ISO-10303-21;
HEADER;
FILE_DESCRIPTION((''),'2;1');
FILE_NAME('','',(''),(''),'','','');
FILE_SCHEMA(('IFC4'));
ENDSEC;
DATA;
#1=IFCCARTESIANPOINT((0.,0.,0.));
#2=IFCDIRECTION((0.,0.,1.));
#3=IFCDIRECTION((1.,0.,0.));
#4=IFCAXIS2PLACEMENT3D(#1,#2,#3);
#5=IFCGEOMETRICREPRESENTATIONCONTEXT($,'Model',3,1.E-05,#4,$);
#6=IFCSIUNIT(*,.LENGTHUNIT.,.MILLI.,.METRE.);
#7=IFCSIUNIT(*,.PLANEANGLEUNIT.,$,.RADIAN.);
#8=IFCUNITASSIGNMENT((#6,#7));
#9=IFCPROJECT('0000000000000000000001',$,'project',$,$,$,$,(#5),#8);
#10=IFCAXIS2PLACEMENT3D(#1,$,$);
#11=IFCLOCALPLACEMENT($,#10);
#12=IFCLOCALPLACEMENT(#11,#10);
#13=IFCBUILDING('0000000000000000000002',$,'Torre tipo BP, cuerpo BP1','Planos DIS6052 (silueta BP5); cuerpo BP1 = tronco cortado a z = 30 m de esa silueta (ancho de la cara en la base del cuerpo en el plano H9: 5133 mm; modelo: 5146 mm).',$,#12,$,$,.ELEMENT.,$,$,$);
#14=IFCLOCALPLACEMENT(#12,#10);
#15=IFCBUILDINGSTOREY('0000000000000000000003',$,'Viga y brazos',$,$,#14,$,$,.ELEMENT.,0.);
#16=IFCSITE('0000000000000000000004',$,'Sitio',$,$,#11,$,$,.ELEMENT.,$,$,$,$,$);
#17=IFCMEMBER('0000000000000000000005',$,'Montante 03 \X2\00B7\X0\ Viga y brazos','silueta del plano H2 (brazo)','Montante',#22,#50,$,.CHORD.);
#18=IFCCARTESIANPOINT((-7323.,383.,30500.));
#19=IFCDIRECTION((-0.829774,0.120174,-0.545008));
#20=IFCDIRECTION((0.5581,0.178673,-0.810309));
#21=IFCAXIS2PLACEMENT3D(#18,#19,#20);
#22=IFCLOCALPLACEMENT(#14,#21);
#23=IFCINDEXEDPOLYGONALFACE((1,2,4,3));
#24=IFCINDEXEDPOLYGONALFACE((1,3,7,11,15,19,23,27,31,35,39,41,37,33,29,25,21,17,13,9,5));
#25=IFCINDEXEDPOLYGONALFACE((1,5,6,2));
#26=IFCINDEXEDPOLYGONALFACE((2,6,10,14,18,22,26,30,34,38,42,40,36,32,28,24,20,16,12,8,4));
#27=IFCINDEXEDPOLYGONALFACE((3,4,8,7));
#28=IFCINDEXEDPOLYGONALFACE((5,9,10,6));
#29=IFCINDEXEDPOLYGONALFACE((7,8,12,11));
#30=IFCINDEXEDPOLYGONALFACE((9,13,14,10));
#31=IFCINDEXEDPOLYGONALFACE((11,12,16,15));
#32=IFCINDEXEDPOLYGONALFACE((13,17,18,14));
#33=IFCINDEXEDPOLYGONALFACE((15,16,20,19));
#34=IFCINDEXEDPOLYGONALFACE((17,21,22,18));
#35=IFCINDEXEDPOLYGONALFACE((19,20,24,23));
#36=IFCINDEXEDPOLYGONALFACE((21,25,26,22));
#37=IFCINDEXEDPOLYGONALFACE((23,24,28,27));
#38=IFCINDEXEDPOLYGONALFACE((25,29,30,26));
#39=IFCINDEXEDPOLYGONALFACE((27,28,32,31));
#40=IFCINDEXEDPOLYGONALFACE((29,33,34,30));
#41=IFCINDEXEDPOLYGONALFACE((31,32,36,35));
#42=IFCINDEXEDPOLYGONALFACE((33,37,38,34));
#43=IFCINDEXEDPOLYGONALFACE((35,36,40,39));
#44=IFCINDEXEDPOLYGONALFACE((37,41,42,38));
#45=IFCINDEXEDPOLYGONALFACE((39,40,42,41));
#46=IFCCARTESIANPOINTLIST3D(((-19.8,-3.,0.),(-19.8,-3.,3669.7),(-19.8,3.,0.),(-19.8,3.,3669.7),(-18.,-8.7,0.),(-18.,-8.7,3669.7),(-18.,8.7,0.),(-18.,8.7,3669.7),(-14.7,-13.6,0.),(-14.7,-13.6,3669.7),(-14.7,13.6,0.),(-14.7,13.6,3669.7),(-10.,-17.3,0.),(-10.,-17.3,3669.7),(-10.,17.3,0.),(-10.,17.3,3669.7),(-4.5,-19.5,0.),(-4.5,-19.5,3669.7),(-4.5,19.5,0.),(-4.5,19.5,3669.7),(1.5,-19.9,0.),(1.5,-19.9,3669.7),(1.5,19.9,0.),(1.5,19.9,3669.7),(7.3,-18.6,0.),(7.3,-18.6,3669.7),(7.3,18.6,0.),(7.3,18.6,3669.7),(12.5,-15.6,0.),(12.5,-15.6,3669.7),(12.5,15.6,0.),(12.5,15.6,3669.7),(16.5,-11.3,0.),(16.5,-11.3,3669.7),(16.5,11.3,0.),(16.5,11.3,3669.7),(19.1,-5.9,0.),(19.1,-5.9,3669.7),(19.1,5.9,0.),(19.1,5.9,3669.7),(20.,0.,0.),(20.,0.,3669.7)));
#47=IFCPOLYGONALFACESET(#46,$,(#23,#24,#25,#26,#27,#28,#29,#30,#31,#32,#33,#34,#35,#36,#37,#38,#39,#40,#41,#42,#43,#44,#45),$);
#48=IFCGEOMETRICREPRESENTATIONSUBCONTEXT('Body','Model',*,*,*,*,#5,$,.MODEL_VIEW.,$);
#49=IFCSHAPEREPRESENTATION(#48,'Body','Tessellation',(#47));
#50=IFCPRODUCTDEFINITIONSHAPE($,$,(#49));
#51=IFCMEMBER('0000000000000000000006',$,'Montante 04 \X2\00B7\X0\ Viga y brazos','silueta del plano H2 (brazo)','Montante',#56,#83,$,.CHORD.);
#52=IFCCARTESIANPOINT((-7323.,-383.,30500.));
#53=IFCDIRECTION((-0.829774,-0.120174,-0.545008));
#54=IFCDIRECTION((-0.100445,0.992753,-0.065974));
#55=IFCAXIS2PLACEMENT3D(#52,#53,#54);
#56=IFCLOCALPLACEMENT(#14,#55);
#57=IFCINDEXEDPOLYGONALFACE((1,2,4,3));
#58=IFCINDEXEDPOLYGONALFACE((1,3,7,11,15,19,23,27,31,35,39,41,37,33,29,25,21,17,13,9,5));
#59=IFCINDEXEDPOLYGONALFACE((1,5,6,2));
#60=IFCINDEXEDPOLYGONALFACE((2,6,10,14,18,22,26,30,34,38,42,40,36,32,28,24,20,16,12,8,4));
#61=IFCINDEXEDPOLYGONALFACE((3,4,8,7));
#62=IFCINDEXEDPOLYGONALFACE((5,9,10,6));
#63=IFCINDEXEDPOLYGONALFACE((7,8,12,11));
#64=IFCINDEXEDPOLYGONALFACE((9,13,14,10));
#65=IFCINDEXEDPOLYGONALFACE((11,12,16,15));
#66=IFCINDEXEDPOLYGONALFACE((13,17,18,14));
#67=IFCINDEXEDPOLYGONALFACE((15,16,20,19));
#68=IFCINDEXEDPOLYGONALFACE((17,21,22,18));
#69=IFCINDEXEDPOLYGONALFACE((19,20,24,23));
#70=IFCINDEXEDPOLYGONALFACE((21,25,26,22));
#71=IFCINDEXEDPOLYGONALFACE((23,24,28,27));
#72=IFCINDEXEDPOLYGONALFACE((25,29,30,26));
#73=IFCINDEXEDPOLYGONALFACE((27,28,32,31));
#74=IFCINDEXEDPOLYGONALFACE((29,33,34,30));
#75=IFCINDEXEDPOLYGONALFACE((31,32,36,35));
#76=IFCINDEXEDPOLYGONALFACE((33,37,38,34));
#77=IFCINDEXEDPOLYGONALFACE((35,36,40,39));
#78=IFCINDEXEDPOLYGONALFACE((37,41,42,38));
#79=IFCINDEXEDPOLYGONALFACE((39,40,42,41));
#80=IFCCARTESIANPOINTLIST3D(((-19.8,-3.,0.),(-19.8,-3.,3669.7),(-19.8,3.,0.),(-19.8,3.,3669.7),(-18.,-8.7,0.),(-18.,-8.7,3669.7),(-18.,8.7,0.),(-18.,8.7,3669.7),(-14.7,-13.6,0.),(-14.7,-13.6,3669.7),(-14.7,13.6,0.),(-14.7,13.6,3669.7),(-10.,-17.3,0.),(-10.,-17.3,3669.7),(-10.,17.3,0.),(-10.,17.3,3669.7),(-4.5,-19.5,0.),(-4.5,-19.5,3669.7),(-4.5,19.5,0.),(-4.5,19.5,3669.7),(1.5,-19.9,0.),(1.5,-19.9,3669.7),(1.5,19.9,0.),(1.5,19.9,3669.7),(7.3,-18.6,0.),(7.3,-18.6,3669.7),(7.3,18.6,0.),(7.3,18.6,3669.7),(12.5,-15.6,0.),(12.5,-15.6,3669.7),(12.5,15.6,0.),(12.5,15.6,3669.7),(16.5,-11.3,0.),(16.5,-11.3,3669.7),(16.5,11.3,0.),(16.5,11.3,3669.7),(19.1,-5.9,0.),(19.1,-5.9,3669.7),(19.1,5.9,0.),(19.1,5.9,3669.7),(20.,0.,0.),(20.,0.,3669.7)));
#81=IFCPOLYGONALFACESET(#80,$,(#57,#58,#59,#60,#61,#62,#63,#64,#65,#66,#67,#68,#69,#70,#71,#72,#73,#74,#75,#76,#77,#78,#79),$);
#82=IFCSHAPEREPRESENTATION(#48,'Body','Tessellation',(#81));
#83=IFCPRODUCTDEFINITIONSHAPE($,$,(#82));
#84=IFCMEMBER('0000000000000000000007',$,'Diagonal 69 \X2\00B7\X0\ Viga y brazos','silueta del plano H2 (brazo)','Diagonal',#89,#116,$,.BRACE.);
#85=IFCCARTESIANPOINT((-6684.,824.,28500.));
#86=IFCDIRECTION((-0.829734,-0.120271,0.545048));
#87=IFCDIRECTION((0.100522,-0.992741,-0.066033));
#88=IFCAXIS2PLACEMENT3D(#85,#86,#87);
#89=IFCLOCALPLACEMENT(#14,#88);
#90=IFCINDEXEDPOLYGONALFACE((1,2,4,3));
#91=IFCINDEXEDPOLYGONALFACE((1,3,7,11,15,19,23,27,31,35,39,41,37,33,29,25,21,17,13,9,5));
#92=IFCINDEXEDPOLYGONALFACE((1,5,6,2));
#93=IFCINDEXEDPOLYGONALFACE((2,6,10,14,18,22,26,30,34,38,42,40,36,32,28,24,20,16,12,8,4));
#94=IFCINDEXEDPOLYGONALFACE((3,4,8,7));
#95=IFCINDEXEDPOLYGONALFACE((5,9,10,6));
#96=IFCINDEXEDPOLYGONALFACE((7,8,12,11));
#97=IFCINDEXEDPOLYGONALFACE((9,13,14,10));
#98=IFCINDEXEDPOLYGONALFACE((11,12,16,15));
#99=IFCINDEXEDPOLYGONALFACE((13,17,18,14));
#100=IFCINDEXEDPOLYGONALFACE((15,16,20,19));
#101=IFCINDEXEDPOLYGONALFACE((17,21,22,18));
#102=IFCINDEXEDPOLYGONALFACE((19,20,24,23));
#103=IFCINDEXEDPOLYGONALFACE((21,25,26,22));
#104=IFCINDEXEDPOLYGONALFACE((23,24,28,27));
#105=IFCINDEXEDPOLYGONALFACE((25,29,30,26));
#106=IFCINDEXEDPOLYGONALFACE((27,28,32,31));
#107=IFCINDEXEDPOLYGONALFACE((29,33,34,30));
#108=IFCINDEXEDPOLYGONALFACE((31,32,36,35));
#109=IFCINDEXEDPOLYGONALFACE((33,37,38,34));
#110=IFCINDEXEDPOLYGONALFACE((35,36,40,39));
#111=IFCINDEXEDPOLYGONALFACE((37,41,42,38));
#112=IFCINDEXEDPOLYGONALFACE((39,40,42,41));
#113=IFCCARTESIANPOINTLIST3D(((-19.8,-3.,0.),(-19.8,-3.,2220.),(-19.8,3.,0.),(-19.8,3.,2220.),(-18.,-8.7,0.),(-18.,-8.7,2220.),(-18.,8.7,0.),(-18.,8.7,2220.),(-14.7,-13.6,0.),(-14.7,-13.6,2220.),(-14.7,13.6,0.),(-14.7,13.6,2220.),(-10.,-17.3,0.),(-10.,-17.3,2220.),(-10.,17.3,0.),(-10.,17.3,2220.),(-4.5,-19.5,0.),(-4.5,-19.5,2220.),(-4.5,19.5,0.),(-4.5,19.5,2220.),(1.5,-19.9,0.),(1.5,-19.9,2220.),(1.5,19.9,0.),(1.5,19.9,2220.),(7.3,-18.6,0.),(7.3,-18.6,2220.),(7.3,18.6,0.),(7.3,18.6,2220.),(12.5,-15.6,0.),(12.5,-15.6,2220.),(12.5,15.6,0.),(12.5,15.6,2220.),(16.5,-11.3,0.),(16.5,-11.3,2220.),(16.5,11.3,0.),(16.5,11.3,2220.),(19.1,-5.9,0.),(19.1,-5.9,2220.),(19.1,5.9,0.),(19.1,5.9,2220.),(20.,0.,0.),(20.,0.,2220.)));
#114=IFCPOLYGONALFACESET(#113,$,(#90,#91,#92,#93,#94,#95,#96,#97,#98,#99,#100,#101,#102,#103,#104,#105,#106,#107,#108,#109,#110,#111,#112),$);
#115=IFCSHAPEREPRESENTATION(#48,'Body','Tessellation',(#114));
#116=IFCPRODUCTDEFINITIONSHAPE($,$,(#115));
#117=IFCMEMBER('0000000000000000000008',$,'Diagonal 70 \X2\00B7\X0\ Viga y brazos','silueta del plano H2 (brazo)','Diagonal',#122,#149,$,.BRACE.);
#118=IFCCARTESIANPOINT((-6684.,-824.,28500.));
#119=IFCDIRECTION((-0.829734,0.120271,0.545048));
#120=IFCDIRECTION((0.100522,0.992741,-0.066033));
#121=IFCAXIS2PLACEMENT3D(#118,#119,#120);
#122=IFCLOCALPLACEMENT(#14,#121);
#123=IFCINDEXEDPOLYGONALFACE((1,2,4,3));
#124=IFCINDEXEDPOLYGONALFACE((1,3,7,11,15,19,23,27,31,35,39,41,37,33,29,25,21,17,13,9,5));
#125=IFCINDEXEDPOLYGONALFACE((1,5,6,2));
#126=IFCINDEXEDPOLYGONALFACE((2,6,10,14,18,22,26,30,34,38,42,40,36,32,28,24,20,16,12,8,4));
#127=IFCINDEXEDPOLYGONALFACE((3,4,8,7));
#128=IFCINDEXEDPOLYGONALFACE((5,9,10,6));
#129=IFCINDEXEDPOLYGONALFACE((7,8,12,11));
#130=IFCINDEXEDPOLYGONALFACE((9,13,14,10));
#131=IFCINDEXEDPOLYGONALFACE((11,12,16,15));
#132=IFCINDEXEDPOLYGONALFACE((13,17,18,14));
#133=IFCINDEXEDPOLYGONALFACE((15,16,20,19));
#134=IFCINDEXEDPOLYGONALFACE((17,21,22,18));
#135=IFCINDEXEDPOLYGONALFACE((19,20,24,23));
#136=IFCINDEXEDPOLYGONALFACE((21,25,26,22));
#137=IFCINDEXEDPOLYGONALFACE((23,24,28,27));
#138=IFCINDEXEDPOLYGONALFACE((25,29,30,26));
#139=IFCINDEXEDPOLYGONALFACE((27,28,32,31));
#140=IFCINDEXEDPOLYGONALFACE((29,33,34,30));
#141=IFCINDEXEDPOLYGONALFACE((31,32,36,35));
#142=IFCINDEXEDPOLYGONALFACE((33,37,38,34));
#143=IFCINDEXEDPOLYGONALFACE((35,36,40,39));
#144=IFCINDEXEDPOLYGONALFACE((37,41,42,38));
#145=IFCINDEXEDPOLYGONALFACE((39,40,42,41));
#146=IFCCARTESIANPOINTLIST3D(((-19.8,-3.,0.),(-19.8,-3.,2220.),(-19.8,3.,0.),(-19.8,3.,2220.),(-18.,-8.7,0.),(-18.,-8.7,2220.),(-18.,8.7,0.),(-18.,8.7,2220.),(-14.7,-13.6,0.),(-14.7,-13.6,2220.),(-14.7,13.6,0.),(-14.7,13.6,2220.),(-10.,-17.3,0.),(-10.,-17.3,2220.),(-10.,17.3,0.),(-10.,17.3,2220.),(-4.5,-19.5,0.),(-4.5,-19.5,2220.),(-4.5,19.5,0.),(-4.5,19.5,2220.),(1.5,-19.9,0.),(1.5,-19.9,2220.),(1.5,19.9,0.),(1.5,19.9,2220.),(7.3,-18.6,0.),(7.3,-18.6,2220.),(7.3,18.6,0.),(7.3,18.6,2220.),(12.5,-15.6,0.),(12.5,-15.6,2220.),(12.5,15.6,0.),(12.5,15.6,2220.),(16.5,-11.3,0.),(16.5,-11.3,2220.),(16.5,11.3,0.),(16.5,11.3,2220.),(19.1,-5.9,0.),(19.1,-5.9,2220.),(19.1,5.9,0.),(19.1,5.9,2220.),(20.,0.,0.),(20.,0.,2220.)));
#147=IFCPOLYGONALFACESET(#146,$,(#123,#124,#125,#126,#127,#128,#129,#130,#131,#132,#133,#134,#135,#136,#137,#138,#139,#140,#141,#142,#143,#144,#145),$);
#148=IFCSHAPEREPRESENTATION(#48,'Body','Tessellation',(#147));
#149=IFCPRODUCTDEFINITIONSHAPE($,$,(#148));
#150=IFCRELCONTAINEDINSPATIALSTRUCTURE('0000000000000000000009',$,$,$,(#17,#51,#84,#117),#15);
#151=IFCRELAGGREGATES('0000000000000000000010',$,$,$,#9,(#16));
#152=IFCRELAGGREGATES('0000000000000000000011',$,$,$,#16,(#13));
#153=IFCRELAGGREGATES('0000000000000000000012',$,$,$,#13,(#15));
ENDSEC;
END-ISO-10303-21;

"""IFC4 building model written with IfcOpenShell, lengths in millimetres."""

from ifc_helpers import new_model, si_unit, frame, origin, origin_with_axes, place, context, subcontext, project, spatial, circle, extrude, element, save


model = new_model("IFC4")

# Units and contexts
model_context = context("Model", 3, precision=1e-05, world=origin_with_axes())
body_context = subcontext(model_context, "Body", "Model", "MODEL_VIEW")
ifc_project = project(units=[si_unit("LENGTHUNIT", "METRE", prefix="MILLI"), si_unit("PLANEANGLEUNIT", "RADIAN")], contexts=[model_context])

# Site, building, storey
site_placement = place(None, origin())
site = spatial("IfcSite", under=ifc_project, at=site_placement, Name="Sitio", CompositionType="ELEMENT")
building_placement = place(site_placement, origin())
building = spatial("IfcBuilding", under=site, at=building_placement, Name="Torre tipo BP, cuerpo BP1", Description="Planos DIS6052 (silueta BP5); cuerpo BP1 = tronco cortado a z = 30 m de esa silueta (ancho de la cara en la base del cuerpo en el plano H9: 5133 mm; modelo: 5146 mm).", CompositionType="ELEMENT")
storey_placement = place(building_placement, origin())
storey = spatial("IfcBuildingStorey", under=building, at=storey_placement, Name="Viga y brazos", CompositionType="ELEMENT", Elevation=0.0)

# Members
for number, where, z_axis, x_axis, name in (
    (1, (-7323.0, 383.0, 30500.0), (-0.829774, 0.120174, -0.545008), (0.5581, 0.178673, -0.810309), "Montante 03 · Viga y brazos"),
    (2, (-7323.0, -383.0, 30500.0), (-0.829774, -0.120174, -0.545008), (-0.100445, 0.992753, -0.065974), "Montante 04 · Viga y brazos"),
):
    element("IfcMember", number, at=place(storey_placement, frame(where, z_axis=z_axis, x_axis=x_axis)), inside=storey, Name=name, Description="silueta del plano H2 (brazo)", ObjectType="Montante", PredefinedType="CHORD", context=body_context, shape_type="SweptSolid", body=[
        extrude(circle(Radius=20.0), None, (0.0, 0.0, 1.0), 3669.7),
    ])
for number, where, z_axis, x_axis, name in (
    (3, (-6684.0, 824.0, 28500.0), (-0.829734, -0.120271, 0.545048), (0.100522, -0.992741, -0.066033), "Diagonal 69 · Viga y brazos"),
    (4, (-6684.0, -824.0, 28500.0), (-0.829734, 0.120271, 0.545048), (0.100522, 0.992741, -0.066033), "Diagonal 70 · Viga y brazos"),
):
    element("IfcMember", number, at=place(storey_placement, frame(where, z_axis=z_axis, x_axis=x_axis)), inside=storey, Name=name, Description="silueta del plano H2 (brazo)", ObjectType="Diagonal", PredefinedType="BRACE", context=body_context, shape_type="SweptSolid", body=[
        extrude(circle(Radius=20.0), None, (0.0, 0.0, 1.0), 2220.0),
    ])

save(model, "model.ifc")
